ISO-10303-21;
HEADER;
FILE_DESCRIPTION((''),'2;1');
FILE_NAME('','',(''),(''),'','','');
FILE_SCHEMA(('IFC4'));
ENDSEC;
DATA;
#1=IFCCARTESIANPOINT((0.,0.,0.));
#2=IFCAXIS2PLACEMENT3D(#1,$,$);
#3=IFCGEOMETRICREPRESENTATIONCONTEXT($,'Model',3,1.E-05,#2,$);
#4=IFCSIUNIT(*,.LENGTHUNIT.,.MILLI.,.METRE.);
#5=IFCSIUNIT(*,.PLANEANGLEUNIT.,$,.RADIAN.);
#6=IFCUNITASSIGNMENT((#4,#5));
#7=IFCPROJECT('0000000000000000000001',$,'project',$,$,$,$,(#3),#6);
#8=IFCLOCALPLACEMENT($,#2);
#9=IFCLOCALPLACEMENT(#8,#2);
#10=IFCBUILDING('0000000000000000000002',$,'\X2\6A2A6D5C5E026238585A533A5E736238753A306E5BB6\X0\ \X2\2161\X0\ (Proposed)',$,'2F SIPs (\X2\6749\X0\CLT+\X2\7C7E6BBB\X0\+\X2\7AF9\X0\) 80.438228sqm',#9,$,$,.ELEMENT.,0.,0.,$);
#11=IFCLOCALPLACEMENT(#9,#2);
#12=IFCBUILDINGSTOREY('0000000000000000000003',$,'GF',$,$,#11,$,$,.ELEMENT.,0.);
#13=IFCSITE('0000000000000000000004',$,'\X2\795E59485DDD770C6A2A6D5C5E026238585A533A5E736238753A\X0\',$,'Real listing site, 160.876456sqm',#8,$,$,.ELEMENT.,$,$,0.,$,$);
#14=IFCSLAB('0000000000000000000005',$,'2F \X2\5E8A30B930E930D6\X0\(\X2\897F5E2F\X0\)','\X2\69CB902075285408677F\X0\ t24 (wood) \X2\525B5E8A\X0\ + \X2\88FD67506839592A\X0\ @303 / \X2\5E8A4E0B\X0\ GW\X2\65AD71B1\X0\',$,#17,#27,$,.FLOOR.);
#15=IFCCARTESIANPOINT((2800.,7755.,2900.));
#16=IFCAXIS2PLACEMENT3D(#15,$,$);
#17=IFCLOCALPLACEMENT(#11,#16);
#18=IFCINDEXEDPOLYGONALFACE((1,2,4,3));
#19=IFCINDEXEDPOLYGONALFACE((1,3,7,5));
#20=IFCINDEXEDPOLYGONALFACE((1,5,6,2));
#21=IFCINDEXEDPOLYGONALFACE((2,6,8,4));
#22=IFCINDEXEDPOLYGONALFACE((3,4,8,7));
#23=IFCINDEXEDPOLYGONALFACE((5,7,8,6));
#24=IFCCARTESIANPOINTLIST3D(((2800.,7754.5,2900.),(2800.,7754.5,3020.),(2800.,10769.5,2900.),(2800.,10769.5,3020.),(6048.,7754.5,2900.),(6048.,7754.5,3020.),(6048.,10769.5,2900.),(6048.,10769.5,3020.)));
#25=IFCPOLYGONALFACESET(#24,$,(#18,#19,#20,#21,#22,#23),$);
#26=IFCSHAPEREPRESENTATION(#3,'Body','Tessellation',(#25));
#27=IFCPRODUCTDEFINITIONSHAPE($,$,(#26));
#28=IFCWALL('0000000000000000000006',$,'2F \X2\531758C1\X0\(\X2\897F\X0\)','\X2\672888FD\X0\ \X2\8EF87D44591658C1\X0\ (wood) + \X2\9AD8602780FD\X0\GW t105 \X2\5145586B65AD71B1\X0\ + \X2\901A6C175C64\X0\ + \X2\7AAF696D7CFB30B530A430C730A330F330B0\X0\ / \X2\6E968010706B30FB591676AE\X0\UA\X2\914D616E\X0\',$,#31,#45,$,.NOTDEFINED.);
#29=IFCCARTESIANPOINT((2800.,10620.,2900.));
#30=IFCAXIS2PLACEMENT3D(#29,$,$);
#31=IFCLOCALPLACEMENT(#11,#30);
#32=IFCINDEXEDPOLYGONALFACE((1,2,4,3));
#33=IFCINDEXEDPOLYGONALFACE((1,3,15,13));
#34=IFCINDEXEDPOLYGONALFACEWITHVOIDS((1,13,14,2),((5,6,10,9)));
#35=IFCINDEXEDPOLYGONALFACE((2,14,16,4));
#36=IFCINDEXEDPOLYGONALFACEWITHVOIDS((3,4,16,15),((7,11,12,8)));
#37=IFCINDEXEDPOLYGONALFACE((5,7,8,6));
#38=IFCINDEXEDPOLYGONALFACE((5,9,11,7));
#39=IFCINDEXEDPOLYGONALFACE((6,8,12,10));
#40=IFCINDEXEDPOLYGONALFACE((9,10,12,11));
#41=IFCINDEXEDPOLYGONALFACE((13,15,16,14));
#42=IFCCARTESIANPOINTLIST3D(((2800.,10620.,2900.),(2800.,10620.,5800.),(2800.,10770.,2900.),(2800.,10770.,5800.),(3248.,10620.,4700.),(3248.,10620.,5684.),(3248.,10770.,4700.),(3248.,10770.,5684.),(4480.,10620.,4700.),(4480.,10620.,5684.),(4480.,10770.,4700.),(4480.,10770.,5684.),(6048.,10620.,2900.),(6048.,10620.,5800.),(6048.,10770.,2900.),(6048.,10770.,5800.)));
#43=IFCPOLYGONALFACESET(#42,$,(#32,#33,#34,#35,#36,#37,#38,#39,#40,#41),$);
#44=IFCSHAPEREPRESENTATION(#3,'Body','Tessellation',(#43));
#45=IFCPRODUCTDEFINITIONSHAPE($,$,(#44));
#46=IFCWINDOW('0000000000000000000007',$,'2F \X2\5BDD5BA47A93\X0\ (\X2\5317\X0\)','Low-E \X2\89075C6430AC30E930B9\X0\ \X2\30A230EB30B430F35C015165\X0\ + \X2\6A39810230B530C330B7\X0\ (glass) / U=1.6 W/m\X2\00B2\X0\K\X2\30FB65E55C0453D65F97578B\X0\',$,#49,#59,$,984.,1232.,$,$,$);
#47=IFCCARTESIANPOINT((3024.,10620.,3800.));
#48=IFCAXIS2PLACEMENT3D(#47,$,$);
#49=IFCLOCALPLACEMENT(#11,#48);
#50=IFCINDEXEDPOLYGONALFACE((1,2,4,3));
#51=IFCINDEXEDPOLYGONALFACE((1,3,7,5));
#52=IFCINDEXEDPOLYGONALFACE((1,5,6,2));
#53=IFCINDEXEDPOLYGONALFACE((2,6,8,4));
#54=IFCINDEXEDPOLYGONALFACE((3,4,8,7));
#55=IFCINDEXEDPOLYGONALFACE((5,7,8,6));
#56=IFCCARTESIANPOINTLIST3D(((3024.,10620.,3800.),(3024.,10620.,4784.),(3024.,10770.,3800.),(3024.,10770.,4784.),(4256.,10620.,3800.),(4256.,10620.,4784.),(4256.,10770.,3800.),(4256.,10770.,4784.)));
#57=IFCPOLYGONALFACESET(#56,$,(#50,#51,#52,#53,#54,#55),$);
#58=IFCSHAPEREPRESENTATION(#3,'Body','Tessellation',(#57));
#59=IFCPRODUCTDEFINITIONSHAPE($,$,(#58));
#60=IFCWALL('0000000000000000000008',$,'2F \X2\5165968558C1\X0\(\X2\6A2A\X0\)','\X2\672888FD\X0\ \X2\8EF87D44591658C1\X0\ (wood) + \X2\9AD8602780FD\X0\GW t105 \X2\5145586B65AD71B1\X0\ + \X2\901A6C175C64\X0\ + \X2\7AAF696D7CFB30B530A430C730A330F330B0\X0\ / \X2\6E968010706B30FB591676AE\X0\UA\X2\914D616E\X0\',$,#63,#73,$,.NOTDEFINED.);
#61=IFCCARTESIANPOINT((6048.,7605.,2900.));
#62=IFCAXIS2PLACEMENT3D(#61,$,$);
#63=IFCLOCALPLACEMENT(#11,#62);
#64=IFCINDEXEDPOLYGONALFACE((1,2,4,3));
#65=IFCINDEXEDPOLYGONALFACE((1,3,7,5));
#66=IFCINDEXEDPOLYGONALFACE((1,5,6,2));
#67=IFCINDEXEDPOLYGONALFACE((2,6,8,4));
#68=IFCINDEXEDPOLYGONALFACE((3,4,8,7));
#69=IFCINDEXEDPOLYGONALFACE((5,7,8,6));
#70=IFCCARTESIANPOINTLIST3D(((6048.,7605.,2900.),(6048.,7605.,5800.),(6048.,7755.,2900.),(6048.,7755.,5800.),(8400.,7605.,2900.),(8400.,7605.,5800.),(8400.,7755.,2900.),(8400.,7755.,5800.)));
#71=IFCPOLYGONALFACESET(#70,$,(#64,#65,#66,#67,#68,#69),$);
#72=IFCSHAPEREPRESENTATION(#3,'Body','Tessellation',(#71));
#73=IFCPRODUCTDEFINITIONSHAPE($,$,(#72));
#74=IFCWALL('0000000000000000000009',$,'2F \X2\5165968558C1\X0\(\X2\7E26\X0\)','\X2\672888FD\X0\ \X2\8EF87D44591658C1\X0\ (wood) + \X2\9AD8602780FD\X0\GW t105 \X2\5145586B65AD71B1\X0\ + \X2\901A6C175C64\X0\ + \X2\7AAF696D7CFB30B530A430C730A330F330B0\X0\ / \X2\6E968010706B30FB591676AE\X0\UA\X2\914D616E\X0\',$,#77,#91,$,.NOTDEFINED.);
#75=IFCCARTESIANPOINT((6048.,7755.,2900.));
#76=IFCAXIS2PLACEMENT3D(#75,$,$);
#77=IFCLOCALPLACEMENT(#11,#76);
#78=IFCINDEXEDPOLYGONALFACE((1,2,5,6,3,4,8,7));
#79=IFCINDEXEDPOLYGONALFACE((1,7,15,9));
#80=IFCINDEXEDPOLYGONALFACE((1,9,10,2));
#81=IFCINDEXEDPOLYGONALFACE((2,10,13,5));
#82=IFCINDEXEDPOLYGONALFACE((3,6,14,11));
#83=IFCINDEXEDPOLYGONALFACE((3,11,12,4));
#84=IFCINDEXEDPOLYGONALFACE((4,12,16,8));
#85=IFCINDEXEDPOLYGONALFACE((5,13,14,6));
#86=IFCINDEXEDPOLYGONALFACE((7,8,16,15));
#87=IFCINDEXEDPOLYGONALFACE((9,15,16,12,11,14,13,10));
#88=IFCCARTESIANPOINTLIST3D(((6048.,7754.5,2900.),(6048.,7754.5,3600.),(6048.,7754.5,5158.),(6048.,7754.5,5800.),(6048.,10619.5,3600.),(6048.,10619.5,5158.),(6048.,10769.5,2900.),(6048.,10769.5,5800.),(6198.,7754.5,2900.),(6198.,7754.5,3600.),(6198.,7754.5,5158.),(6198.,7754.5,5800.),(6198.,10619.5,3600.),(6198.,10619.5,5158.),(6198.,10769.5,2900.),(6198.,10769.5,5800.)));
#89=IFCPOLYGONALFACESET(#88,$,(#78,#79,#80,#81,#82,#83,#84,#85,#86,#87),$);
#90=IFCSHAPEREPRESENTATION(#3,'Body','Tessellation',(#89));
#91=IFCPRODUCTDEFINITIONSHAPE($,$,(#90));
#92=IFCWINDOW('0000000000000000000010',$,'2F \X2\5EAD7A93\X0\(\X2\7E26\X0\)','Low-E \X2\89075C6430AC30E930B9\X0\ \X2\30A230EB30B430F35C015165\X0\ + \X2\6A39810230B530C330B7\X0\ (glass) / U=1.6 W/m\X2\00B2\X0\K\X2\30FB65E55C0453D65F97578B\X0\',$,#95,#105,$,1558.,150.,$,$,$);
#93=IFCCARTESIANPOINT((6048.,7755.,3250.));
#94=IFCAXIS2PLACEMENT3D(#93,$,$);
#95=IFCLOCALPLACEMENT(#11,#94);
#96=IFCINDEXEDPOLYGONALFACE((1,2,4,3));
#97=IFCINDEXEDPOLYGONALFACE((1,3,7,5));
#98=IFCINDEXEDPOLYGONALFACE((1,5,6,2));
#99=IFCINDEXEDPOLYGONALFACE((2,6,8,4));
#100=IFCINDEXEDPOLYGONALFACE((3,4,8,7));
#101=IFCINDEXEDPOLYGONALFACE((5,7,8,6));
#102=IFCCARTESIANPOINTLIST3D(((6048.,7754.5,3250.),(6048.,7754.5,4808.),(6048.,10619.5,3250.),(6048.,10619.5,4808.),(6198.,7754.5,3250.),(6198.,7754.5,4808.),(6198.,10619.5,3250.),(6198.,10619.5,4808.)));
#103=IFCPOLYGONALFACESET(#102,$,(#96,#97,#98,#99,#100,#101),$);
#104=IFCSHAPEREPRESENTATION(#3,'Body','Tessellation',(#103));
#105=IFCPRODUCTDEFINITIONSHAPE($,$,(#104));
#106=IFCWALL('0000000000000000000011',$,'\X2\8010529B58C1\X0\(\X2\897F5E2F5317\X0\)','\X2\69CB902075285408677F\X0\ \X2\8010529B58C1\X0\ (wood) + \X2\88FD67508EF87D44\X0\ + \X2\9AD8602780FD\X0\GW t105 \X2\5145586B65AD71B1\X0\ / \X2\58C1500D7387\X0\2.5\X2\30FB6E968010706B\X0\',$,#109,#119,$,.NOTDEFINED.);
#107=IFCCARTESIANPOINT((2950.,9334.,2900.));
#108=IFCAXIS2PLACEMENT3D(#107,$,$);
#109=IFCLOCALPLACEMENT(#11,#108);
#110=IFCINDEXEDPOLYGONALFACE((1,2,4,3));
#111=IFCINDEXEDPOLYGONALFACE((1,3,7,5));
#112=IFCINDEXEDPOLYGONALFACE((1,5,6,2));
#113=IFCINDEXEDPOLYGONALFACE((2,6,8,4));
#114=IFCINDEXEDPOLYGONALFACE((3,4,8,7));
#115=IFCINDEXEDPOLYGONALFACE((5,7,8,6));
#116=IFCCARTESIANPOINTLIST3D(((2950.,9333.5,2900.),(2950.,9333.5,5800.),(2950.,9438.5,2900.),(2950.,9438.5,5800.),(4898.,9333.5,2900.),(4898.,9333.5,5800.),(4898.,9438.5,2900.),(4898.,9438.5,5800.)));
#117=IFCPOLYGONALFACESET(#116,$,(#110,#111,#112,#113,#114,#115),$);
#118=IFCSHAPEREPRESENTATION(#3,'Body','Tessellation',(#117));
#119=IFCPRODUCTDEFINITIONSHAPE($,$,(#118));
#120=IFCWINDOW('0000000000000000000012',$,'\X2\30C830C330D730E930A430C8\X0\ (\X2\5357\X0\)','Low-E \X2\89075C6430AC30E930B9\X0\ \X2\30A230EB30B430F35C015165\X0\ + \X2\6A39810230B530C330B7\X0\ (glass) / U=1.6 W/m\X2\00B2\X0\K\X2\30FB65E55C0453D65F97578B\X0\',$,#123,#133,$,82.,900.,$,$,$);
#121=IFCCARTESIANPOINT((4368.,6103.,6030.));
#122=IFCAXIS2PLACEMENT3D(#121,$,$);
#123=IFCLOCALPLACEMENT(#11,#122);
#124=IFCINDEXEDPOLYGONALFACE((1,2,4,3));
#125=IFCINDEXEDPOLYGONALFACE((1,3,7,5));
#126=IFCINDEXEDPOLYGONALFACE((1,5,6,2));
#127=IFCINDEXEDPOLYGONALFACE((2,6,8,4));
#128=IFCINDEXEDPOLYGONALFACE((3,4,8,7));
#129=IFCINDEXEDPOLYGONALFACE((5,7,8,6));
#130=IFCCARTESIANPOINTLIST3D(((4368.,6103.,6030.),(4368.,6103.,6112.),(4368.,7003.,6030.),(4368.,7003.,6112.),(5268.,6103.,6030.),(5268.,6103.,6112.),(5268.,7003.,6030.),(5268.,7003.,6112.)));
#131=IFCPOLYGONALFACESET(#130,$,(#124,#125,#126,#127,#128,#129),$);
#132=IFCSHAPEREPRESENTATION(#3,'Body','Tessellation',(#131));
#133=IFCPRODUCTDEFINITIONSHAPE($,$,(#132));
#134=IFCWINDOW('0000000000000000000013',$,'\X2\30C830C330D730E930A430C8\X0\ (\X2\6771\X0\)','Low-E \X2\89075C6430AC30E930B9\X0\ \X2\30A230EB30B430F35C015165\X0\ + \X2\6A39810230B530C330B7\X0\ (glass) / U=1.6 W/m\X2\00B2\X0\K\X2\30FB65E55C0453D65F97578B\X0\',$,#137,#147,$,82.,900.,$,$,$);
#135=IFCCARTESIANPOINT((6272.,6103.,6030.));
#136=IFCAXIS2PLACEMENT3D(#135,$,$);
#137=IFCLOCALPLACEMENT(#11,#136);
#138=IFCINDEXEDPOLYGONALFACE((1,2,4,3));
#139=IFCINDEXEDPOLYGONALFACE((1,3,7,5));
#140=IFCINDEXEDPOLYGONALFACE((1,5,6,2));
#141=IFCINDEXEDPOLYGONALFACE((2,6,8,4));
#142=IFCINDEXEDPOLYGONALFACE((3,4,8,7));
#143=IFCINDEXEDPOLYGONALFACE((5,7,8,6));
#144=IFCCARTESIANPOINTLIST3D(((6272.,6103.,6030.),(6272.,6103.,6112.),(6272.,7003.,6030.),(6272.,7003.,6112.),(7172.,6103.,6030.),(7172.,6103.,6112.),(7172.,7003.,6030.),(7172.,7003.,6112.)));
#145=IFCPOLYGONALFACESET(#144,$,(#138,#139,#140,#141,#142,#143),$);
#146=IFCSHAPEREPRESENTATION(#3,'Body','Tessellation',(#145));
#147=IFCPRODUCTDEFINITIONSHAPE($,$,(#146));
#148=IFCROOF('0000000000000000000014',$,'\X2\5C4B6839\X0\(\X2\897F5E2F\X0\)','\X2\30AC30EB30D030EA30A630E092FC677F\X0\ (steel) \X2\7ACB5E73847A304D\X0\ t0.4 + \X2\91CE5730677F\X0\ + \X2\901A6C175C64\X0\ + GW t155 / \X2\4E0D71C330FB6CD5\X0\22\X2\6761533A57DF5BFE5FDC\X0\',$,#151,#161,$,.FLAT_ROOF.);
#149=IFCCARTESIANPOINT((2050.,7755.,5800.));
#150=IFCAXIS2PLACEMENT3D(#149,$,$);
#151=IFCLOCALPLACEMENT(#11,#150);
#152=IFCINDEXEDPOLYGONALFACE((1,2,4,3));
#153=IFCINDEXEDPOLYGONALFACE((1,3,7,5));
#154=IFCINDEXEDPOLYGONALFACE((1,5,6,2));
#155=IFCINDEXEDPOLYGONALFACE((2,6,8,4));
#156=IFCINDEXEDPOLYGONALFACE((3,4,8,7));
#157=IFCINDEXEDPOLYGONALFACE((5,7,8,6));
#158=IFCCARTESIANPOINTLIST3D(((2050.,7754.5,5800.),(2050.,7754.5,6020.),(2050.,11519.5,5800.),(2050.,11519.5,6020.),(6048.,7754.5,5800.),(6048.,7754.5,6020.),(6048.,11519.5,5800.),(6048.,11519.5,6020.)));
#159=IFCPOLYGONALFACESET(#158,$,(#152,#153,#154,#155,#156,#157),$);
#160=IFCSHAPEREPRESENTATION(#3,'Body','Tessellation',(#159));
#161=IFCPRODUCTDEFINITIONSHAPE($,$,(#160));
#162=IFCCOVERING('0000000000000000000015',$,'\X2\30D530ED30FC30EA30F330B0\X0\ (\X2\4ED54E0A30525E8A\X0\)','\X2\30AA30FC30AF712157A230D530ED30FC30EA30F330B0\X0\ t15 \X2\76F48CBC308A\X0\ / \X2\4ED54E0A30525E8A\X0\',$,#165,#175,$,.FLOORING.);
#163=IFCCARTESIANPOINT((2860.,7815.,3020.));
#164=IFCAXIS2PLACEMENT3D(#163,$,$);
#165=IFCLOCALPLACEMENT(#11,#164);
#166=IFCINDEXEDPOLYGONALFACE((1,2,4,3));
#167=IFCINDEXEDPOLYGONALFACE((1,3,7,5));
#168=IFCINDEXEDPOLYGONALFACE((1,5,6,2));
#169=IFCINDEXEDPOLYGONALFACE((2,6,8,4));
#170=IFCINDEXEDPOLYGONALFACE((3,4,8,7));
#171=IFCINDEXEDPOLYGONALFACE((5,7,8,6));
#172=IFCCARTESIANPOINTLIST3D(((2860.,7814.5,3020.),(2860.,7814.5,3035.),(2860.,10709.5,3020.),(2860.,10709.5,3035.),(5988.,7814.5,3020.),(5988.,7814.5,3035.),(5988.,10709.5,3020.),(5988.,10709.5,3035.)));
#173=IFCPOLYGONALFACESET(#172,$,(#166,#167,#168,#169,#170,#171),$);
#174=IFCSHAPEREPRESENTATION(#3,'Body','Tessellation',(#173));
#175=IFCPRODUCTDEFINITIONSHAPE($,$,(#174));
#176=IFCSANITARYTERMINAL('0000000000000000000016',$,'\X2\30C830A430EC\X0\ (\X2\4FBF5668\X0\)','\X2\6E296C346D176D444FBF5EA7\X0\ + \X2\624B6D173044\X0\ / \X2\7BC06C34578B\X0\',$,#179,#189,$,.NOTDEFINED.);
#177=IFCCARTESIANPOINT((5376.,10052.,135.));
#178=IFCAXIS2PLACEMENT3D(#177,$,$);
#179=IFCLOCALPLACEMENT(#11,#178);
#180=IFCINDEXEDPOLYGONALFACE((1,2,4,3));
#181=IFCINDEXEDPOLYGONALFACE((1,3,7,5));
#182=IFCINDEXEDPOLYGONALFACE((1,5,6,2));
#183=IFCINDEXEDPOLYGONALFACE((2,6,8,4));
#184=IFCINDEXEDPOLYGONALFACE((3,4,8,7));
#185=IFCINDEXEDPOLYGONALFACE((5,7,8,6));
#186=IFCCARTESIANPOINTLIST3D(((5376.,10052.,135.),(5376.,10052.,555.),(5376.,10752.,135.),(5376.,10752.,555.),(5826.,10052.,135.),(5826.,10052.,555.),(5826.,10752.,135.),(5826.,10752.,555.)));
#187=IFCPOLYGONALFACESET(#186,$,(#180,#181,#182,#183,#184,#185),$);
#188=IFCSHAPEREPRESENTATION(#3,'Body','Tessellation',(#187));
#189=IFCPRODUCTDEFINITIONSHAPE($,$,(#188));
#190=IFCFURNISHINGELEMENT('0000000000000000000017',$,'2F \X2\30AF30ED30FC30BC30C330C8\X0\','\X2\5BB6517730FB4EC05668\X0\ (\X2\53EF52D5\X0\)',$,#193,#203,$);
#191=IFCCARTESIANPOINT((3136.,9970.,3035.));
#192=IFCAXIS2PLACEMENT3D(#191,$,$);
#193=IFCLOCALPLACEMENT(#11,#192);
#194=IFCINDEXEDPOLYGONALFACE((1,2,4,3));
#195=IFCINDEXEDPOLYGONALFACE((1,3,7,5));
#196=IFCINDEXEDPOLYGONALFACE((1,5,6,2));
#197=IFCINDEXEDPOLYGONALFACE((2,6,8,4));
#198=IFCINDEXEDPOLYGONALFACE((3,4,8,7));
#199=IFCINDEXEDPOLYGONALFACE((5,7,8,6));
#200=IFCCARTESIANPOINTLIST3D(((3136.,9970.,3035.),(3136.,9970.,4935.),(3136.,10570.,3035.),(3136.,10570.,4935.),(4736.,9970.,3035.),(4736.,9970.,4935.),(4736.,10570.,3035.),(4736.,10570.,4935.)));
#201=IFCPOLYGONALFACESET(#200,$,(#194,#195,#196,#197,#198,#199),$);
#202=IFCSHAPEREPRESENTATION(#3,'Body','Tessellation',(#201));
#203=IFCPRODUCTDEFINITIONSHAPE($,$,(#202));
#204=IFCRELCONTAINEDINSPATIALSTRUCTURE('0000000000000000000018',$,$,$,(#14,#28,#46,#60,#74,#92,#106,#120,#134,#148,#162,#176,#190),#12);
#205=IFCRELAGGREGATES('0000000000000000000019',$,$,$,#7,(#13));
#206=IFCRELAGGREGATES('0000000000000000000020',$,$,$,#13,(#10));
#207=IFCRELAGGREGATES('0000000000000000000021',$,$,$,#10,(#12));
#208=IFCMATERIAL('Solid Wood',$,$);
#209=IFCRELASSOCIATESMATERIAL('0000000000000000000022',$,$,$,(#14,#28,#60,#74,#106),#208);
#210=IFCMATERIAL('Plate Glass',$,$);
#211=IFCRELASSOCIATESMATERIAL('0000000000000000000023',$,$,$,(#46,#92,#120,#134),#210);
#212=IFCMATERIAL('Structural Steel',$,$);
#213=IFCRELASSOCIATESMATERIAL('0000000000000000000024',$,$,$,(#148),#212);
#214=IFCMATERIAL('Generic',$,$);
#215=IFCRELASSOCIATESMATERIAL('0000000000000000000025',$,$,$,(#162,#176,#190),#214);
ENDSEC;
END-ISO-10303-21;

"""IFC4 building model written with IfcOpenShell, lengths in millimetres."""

from ifc_helpers import new_model, si_unit, frame, frame_2d, origin, place, context, project, spatial, rectangle, extrude, material, element, fill, save


model = new_model("IFC4")

# Units and contexts
model_context = context("Model", 3, precision=1e-05, world=origin())
ifc_project = project(units=[si_unit("LENGTHUNIT", "METRE", prefix="MILLI"), si_unit("PLANEANGLEUNIT", "RADIAN")], contexts=[model_context])

# Site, building, storey
site_placement = place(None, origin())
site = spatial("IfcSite", under=ifc_project, at=site_placement, Name="神奈川県横浜市戸塚区平戸町", ObjectType="Real listing site, 160.876456sqm", CompositionType="ELEMENT", RefElevation=0.0)
building_placement = place(site_placement, origin())
building = spatial("IfcBuilding", under=site, at=building_placement, Name="横浜市戸塚区平戸町の家 Ⅱ (Proposed)", ObjectType="2F SIPs (杉CLT+籾殻+竹) 80.438228sqm", CompositionType="ELEMENT", ElevationOfRefHeight=0.0, ElevationOfTerrain=0.0)
storey_placement = place(building_placement, origin())
storey = spatial("IfcBuildingStorey", under=building, at=storey_placement, Name="GF", CompositionType="ELEMENT", Elevation=0.0)

# Slab
ifc_material_1 = material(Name="Solid Wood")
slab_placement = place(storey_placement, frame((2800.0, 7755.0, 2900.0)))
element("IfcSlab", 1, at=slab_placement, inside=storey, material=ifc_material_1, Name="2F 床スラブ(西帯)", Description="構造用合板 t24 (wood) 剛床 + 製材根太 @303 / 床下 GW断熱", PredefinedType="FLOOR", context=model_context, shape_type="SweptSolid", body=[
    extrude(rectangle(XDim=3248.0, YDim=3015.0, at=frame_2d((1624.0, 1507.0))), frame((2800.0, 7755.0, 2900.0)), (0.0, 0.0, 1.0), 120.0),
])

# Wall, opening, window
wall_1_placement = place(storey_placement, frame((2800.0, 10620.0, 2900.0)))
wall_1 = element("IfcWall", 2, at=wall_1_placement, inside=storey, material=ifc_material_1, Name="2F 北壁(西)", Description="木製 軸組外壁 (wood) + 高性能GW t105 充填断熱 + 通気層 + 窯業系サイディング / 準耐火・外皮UA配慮", PredefinedType="NOTDEFINED", context=model_context, shape_type="SweptSolid", body=[
    extrude(rectangle(XDim=3248.0, YDim=150.0, at=frame_2d((1624.0, 75.0))), frame((2800.0, 10620.0, 2900.0)), (0.0, 0.0, 1.0), 2900.0),
])
opening_1_placement = place(storey_placement, frame((3024.0, 10620.0, 3800.0)))
opening_1 = element("IfcOpeningElement", 3, at=opening_1_placement, cuts=wall_1, PredefinedType="NOTDEFINED", context=model_context, shape_type="SweptSolid", body=[
    extrude(rectangle(XDim=1232.0, YDim=150.0, at=frame_2d((616.0, 75.0))), frame((3024.0, 10620.0, 3800.0)), (0.0, 0.0, 1.0), 984.0),
])
ifc_material_2 = material(Name="Plate Glass")
window_1_placement = place(storey_placement, frame((3024.0, 10620.0, 3800.0)))
window_1 = element("IfcWindow", 4, at=window_1_placement, inside=storey, material=ifc_material_2, Name="2F 寝室窓 (北)", Description="Low-E 複層ガラス アルゴン封入 + 樹脂サッシ (glass) / U=1.6 W/m²K・日射取得型", OverallHeight=984.0, OverallWidth=1232.0, context=model_context, shape_type="SweptSolid", body=[
    extrude(rectangle(XDim=1232.0, YDim=150.0, at=frame_2d((616.0, 75.0))), frame((3024.0, 10620.0, 3800.0)), (0.0, 0.0, 1.0), 984.0),
])
fill(opening_1, window_1)

# Wall
wall_2_placement = place(storey_placement, frame((6048.0, 7605.0, 2900.0)))
element("IfcWall", 5, at=wall_2_placement, inside=storey, material=ifc_material_1, Name="2F 入隅壁(横)", Description="木製 軸組外壁 (wood) + 高性能GW t105 充填断熱 + 通気層 + 窯業系サイディング / 準耐火・外皮UA配慮", PredefinedType="NOTDEFINED", context=model_context, shape_type="SweptSolid", body=[
    extrude(rectangle(XDim=2352.0, YDim=150.0, at=frame_2d((1176.0, 75.0))), frame((6048.0, 7605.0, 2900.0)), (0.0, 0.0, 1.0), 2900.0),
])

# Wall, opening, window
wall_3_placement = place(storey_placement, frame((6048.0, 7755.0, 2900.0)))
wall_3 = element("IfcWall", 6, at=wall_3_placement, inside=storey, material=ifc_material_1, Name="2F 入隅壁(縦)", Description="木製 軸組外壁 (wood) + 高性能GW t105 充填断熱 + 通気層 + 窯業系サイディング / 準耐火・外皮UA配慮", PredefinedType="NOTDEFINED", context=model_context, shape_type="SweptSolid", body=[
    extrude(rectangle(XDim=150.0, YDim=3015.0, at=frame_2d((75.0, 1507.0))), frame((6048.0, 7755.0, 2900.0)), (0.0, 0.0, 1.0), 2900.0),
])
opening_2_placement = place(storey_placement, frame((6048.0, 7755.0, 3250.0)))
opening_2 = element("IfcOpeningElement", 7, at=opening_2_placement, cuts=wall_3, PredefinedType="NOTDEFINED", context=model_context, shape_type="SweptSolid", body=[
    extrude(rectangle(XDim=150.0, YDim=2865.0, at=frame_2d((75.0, 1432.0))), frame((6048.0, 7755.0, 3250.0)), (0.0, 0.0, 1.0), 1558.0),
])
window_2_placement = place(storey_placement, frame((6048.0, 7755.0, 3250.0)))
window_2 = element("IfcWindow", 8, at=window_2_placement, inside=storey, material=ifc_material_2, Name="2F 庭窓(縦)", Description="Low-E 複層ガラス アルゴン封入 + 樹脂サッシ (glass) / U=1.6 W/m²K・日射取得型", OverallHeight=1558.0, OverallWidth=150.0, context=model_context, shape_type="SweptSolid", body=[
    extrude(rectangle(XDim=150.0, YDim=2865.0, at=frame_2d((75.0, 1432.0))), frame((6048.0, 7755.0, 3250.0)), (0.0, 0.0, 1.0), 1558.0),
])
fill(opening_2, window_2)

# Wall
wall_4_placement = place(storey_placement, frame((2950.0, 9334.0, 2900.0)))
element("IfcWall", 9, at=wall_4_placement, inside=storey, material=ifc_material_1, Name="耐力壁(西帯北)", Description="構造用合板 耐力壁 (wood) + 製材軸組 + 高性能GW t105 充填断熱 / 壁倍率2.5・準耐火", PredefinedType="NOTDEFINED", context=model_context, shape_type="SweptSolid", body=[
    extrude(rectangle(XDim=1948.0, YDim=105.0, at=frame_2d((974.0, 52.0))), frame((2950.0, 9334.0, 2900.0)), (0.0, 0.0, 1.0), 2900.0),
])

# Windows
window_3_placement = place(storey_placement, frame((4368.0, 6103.0, 6030.0)))
element("IfcWindow", 10, at=window_3_placement, inside=storey, material=ifc_material_2, Name="トップライト (南)", Description="Low-E 複層ガラス アルゴン封入 + 樹脂サッシ (glass) / U=1.6 W/m²K・日射取得型", OverallHeight=82.0, OverallWidth=900.0, context=model_context, shape_type="SweptSolid", body=[
    extrude(rectangle(XDim=900.0, YDim=900.0, at=frame_2d((450.0, 450.0))), frame((4368.0, 6103.0, 6030.0)), (0.0, 0.0, 1.0), 82.0),
])
window_4_placement = place(storey_placement, frame((6272.0, 6103.0, 6030.0)))
element("IfcWindow", 11, at=window_4_placement, inside=storey, material=ifc_material_2, Name="トップライト (東)", Description="Low-E 複層ガラス アルゴン封入 + 樹脂サッシ (glass) / U=1.6 W/m²K・日射取得型", OverallHeight=82.0, OverallWidth=900.0, context=model_context, shape_type="SweptSolid", body=[
    extrude(rectangle(XDim=900.0, YDim=900.0, at=frame_2d((450.0, 450.0))), frame((6272.0, 6103.0, 6030.0)), (0.0, 0.0, 1.0), 82.0),
])

# Roof
ifc_material_3 = material(Name="Structural Steel")
for number, where, name in (
    (12, (2050.0, 7755.0, 5800.0), "屋根(西帯)"),
):
    element("IfcRoof", number, at=place(storey_placement, frame(where)), inside=storey, material=ifc_material_3, Name=name, Description="ガルバリウム鋼板 (steel) 立平葺き t0.4 + 野地板 + 通気層 + GW t155 / 不燃・法22条区域対応", PredefinedType="FLAT_ROOF", context=model_context, shape_type="SweptSolid", body=[
        extrude(rectangle(XDim=3998.0, YDim=3765.0, at=frame_2d((1999.0, 1882.0))), frame((2050.0, 7755.0, 5800.0)), (0.0, 0.0, 1.0), 220.0),
    ])

# Covering
ifc_material_4 = material(Name="Generic")
covering_placement = place(storey_placement, frame((2860.0, 7815.0, 3020.0)))
element("IfcCovering", 13, at=covering_placement, inside=storey, material=ifc_material_4, Name="フローリング (仕上げ床)", Description="オーク無垢フローリング t15 直貼り / 仕上げ床", PredefinedType="FLOORING", context=model_context, shape_type="SweptSolid", body=[
    extrude(rectangle(XDim=3128.0, YDim=2895.0, at=frame_2d((1564.0, 1447.0))), frame((2860.0, 7815.0, 3020.0)), (0.0, 0.0, 1.0), 15.0),
])

# Sanitary terminal
sanitary_terminal_placement = place(storey_placement, frame((5376.0, 10052.0, 135.0)))
element("IfcSanitaryTerminal", 14, at=sanitary_terminal_placement, inside=storey, material=ifc_material_4, Name="トイレ (便器)", Description="温水洗浄便座 + 手洗い / 節水型", PredefinedType="NOTDEFINED", context=model_context, shape_type="SweptSolid", body=[
    extrude(rectangle(XDim=450.0, YDim=700.0, at=frame_2d((225.0, 350.0))), frame((5376.0, 10052.0, 135.0)), (0.0, 0.0, 1.0), 420.0),
])

# Furnishing element
furnishing_1_placement = place(storey_placement, frame((3136.0, 9970.0, 3035.0)))
element("IfcFurnishingElement", 15, at=furnishing_1_placement, inside=storey, material=ifc_material_4, Name="2F クローゼット", Description="家具・什器 (可動)", context=model_context, shape_type="SweptSolid", body=[
    extrude(rectangle(XDim=1600.0, YDim=600.0, at=frame_2d((800.0, 300.0))), frame((3136.0, 9970.0, 3035.0)), (0.0, 0.0, 1.0), 1900.0),
])

save(model, "model.ifc")
